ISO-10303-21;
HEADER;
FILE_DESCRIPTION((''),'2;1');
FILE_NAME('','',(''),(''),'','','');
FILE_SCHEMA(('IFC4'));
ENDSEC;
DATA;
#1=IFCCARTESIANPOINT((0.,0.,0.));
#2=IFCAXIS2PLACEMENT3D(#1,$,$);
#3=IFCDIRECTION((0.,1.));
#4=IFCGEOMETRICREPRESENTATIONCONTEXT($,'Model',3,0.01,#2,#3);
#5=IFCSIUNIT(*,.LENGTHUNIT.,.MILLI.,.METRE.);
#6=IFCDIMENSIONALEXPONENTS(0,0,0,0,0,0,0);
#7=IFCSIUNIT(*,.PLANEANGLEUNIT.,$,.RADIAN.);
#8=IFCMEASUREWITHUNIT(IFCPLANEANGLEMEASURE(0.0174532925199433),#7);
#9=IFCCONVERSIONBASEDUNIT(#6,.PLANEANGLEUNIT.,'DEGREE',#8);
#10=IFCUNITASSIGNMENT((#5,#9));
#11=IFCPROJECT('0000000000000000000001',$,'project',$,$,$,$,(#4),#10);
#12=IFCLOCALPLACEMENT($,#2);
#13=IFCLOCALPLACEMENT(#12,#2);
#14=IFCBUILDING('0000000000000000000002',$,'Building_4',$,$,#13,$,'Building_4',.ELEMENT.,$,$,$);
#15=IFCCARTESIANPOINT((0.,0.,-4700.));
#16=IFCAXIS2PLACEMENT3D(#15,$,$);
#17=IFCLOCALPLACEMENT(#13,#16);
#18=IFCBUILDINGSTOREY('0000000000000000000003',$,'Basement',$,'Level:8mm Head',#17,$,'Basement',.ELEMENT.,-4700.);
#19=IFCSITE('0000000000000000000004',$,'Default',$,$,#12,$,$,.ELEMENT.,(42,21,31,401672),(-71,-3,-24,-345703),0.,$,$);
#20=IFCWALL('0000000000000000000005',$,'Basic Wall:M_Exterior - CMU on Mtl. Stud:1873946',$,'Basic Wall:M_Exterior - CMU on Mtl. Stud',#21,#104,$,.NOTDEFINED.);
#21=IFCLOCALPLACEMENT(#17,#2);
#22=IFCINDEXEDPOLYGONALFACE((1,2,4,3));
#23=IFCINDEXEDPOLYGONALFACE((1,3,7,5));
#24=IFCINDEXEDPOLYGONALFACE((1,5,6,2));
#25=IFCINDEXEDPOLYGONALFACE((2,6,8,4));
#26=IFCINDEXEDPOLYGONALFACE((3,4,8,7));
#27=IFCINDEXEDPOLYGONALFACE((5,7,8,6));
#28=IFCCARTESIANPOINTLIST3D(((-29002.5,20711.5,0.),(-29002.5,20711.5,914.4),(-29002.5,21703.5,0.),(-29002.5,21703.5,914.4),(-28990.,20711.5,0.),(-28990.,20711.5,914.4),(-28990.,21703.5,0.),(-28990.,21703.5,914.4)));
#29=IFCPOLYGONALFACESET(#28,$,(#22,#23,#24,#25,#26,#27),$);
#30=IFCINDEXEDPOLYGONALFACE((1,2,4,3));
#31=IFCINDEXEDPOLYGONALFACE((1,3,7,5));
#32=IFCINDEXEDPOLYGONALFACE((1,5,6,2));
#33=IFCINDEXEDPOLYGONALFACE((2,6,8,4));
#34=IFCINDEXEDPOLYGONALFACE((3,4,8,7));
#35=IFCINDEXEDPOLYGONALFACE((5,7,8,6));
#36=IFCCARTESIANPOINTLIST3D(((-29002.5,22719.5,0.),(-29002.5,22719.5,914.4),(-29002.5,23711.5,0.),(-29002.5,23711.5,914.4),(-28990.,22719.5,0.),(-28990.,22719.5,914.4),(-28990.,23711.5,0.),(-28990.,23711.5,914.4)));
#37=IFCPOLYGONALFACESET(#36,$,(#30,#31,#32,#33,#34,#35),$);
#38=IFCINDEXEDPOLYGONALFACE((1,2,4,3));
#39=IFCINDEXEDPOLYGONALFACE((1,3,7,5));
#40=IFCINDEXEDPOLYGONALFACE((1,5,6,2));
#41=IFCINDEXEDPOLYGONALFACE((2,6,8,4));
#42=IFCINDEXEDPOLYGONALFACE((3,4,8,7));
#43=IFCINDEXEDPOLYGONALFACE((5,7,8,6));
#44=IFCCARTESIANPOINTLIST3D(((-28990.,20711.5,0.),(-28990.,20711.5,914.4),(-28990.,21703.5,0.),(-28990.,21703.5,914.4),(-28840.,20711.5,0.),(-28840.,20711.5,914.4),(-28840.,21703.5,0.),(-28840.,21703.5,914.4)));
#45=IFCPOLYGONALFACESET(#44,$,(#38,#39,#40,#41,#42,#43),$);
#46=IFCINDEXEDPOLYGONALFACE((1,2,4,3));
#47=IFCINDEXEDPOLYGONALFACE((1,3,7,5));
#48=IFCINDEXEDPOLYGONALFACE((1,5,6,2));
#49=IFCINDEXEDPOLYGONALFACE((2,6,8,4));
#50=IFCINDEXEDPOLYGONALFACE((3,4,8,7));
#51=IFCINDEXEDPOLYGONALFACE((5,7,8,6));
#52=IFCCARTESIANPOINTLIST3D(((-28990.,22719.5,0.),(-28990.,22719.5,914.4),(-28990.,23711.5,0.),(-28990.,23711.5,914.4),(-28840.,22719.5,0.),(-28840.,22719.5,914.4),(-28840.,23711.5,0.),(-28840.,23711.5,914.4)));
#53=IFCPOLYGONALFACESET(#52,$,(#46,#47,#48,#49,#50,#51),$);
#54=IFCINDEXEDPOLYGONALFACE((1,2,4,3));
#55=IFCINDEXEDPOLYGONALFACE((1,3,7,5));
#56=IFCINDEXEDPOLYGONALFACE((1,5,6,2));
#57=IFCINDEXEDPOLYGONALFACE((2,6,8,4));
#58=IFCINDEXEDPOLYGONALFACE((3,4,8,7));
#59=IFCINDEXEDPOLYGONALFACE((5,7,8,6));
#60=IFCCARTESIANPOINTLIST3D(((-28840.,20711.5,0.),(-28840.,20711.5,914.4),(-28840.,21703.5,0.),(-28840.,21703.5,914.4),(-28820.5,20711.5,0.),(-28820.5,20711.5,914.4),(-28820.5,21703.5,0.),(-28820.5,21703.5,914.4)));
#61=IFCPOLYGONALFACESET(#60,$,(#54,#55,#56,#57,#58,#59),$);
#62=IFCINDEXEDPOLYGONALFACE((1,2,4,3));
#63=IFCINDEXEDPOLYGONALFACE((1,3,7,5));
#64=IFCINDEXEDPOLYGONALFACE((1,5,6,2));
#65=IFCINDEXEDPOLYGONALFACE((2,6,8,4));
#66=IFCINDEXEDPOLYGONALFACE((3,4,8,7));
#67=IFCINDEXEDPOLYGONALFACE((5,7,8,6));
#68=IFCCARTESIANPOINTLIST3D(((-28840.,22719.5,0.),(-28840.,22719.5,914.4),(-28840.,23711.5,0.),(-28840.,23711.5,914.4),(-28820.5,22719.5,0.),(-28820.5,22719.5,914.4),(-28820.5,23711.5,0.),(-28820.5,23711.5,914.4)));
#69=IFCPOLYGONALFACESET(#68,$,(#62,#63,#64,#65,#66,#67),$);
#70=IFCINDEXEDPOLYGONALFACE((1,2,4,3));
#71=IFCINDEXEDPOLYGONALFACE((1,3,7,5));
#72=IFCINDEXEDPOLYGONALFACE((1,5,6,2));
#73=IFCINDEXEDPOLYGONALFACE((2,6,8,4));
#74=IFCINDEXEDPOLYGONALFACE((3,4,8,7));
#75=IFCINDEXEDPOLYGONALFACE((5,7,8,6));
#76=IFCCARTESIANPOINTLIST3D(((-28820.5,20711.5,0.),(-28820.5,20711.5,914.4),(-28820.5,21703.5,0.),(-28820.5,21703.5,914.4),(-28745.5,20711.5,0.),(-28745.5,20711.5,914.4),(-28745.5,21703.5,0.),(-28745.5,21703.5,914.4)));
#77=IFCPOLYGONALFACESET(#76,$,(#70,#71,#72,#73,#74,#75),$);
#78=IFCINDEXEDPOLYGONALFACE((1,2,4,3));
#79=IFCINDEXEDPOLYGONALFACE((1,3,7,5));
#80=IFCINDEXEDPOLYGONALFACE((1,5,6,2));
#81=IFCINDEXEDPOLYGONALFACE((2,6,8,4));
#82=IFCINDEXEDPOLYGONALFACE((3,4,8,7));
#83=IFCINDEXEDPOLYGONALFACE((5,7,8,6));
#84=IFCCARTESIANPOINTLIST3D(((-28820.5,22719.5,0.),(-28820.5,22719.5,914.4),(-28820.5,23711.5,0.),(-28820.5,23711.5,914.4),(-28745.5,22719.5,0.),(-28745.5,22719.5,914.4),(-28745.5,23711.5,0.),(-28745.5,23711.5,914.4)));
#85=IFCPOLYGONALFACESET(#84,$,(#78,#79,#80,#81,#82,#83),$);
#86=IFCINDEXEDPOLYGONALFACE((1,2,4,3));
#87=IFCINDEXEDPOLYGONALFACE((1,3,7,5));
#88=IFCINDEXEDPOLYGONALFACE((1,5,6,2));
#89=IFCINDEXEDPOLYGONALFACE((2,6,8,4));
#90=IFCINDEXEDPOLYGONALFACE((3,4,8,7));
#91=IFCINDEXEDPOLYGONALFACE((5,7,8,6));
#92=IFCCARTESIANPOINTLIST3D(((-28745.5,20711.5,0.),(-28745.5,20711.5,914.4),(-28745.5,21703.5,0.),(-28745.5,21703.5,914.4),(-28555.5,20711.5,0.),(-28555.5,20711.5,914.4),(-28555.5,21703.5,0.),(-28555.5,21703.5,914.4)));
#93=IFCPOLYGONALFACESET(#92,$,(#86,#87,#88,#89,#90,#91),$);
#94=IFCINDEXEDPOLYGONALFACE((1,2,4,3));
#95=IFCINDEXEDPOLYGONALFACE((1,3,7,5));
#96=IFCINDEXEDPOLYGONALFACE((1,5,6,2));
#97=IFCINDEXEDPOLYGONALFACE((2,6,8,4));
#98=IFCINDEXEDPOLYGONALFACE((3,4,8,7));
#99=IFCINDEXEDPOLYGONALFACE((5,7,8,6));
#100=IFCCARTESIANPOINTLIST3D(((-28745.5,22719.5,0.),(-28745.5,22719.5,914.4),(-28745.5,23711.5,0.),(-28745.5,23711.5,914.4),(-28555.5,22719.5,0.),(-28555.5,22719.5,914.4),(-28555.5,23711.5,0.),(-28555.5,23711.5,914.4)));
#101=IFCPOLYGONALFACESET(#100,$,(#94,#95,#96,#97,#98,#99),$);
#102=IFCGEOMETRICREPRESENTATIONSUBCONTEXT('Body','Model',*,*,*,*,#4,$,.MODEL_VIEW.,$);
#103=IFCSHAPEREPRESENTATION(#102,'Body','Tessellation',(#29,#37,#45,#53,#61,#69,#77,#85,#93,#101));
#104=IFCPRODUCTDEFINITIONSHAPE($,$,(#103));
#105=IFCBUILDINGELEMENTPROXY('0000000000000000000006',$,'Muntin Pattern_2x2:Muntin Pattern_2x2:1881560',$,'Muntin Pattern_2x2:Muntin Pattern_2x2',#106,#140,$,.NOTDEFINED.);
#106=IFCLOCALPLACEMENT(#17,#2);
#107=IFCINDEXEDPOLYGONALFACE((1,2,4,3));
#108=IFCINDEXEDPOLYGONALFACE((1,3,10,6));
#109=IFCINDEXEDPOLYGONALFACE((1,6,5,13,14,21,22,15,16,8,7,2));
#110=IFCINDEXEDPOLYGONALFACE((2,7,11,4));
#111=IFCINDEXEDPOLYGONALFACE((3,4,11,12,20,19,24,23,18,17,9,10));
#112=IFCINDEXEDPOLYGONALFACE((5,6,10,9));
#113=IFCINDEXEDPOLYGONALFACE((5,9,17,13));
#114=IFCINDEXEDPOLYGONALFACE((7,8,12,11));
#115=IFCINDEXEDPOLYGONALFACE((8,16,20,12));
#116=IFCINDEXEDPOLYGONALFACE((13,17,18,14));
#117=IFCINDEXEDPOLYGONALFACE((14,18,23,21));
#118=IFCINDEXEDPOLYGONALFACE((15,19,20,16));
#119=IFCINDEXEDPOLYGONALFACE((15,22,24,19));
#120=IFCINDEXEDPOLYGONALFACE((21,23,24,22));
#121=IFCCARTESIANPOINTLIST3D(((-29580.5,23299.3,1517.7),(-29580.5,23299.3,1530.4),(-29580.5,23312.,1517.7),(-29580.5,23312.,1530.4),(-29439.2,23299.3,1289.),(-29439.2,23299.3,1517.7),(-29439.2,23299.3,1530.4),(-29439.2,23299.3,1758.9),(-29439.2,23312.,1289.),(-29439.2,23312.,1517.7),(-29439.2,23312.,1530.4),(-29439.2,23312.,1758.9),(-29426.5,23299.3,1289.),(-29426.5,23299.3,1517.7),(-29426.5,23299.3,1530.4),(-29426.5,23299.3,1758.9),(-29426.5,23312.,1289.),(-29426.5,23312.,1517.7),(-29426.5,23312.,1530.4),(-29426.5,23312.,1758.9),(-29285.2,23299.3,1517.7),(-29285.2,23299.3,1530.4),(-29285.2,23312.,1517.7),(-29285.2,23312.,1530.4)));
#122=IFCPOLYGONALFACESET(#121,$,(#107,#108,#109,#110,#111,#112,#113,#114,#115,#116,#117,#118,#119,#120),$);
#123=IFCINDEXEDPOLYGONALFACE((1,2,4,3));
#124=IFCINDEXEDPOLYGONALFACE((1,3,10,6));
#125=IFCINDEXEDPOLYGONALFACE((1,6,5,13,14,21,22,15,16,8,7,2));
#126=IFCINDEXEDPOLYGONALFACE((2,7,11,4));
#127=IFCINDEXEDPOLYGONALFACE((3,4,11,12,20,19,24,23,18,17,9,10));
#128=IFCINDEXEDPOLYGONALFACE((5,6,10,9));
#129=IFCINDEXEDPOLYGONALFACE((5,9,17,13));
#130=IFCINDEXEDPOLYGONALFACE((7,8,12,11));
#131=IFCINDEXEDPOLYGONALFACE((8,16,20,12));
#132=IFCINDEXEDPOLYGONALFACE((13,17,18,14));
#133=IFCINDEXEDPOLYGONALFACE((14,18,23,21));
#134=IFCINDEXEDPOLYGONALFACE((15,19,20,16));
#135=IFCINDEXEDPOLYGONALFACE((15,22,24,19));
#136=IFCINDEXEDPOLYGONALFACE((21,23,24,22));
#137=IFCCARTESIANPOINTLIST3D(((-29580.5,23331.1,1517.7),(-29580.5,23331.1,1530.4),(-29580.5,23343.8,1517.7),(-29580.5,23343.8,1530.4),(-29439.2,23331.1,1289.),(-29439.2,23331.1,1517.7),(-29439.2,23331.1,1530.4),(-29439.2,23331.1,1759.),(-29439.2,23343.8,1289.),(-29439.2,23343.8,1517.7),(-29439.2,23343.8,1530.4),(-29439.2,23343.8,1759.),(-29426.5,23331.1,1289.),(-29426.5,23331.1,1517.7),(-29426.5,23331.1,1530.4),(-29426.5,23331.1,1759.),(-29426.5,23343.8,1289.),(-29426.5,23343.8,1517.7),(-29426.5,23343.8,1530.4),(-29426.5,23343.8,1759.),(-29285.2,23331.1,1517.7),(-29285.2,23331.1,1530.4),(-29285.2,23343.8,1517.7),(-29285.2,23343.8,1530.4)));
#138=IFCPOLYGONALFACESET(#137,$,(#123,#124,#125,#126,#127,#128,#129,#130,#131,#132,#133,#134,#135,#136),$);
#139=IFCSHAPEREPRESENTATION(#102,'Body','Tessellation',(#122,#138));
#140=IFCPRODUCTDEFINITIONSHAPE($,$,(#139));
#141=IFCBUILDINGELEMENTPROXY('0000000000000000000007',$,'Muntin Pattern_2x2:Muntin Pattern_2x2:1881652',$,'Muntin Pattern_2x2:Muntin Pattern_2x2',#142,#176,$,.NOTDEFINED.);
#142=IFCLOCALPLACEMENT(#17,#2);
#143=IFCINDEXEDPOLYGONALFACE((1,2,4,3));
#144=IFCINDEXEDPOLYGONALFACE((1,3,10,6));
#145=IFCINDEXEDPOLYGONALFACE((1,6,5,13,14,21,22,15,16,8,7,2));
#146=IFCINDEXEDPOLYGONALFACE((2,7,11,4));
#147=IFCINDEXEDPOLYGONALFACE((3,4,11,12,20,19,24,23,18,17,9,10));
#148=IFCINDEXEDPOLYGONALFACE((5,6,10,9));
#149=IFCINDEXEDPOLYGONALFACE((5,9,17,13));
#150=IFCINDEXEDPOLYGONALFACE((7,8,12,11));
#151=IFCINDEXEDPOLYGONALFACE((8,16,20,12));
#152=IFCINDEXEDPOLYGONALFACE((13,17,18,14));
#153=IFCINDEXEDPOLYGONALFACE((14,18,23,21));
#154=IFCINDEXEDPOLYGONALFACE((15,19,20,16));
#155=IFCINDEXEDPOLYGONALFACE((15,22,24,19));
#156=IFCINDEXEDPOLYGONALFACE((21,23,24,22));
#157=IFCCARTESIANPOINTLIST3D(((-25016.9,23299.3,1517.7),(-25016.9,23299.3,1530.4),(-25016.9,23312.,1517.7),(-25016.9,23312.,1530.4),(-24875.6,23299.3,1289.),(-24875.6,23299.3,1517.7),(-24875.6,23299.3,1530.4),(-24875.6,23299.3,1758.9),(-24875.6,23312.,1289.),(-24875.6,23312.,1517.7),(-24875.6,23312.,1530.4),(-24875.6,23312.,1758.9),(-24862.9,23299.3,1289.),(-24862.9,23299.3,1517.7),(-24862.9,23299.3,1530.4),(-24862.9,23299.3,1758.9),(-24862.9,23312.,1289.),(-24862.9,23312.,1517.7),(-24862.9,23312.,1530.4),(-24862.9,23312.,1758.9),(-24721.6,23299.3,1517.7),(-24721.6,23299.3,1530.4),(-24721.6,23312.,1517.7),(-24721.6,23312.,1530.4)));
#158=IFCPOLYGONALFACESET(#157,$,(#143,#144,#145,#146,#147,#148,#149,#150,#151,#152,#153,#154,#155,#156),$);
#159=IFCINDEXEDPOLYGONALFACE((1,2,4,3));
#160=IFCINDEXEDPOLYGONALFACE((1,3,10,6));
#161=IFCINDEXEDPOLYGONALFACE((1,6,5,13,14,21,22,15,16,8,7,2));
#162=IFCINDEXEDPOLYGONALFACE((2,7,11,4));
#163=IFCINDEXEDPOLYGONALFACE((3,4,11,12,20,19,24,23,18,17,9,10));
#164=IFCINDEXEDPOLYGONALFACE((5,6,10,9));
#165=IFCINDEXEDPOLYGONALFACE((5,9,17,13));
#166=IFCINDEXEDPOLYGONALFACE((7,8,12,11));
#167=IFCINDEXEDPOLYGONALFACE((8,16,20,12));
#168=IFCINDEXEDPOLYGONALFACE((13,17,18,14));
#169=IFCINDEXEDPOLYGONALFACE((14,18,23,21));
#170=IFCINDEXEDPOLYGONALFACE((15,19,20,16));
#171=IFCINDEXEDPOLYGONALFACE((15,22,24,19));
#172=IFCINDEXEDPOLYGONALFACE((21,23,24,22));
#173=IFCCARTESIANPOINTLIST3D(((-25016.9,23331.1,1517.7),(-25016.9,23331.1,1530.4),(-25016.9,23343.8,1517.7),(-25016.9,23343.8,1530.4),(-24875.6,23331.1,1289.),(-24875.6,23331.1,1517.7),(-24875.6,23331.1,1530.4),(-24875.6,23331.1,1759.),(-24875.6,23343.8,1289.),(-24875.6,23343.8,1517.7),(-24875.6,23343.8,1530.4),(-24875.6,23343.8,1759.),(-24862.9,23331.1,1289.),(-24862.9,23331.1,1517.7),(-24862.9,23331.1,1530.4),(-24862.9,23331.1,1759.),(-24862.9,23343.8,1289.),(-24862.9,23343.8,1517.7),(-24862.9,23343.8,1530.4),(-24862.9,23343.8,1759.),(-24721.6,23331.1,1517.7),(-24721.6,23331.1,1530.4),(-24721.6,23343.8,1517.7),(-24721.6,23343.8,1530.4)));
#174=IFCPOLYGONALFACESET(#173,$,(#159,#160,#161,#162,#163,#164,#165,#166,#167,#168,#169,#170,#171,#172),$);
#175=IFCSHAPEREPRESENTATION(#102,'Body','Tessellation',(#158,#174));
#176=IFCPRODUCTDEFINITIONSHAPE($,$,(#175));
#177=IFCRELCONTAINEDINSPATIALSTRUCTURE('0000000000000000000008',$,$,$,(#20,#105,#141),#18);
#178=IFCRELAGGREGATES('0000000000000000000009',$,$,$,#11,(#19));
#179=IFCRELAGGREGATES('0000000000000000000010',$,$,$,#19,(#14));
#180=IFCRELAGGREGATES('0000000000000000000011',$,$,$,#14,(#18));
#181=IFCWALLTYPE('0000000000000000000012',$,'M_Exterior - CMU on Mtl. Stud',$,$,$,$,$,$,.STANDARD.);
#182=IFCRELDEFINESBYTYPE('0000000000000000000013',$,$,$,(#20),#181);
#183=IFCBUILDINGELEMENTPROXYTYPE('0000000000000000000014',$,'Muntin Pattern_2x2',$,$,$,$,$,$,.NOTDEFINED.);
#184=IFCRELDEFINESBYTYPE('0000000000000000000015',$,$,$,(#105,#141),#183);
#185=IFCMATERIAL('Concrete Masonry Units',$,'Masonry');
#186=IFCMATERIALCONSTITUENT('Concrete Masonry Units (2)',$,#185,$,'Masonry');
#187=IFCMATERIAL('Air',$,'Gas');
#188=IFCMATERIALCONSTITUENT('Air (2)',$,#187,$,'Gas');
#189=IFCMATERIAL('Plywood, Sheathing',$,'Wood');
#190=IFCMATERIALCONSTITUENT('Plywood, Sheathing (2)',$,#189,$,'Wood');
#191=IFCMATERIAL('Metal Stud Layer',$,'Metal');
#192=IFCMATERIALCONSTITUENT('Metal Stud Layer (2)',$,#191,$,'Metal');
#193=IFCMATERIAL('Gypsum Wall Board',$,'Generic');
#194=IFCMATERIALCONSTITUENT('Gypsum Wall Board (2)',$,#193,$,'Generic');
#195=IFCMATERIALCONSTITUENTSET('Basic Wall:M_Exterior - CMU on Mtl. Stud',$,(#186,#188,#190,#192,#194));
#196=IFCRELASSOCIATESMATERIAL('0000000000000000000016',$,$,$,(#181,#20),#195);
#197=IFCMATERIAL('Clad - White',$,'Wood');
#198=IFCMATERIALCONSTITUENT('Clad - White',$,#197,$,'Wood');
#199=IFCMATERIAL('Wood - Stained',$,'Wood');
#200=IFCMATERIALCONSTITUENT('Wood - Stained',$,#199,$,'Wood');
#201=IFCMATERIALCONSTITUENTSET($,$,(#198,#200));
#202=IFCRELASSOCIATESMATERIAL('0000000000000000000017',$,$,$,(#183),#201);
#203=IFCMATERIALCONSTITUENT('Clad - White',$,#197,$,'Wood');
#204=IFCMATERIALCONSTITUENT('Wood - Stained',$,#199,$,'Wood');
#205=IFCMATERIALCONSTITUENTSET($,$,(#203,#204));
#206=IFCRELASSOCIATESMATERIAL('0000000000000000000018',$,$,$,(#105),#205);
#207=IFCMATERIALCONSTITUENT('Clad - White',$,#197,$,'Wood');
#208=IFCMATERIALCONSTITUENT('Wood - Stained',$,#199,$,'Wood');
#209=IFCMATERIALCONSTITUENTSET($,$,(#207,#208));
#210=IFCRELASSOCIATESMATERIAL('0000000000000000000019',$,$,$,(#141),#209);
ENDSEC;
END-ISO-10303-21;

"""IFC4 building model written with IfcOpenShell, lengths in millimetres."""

from ifc_helpers import new_model, entity, si_unit, converted_unit, direction, frame, origin, place, context, subcontext, project, spatial, indexed_curve, outline, extrude, source, transform, mapped, material, constituent, constituent_set, type_object, type_shapes, element, save


model = new_model("IFC4")

# Units and contexts
model_context = context("Model", 3, precision=0.01, world=origin(), true_north=direction((0.0, 1.0)))
body_context = subcontext(model_context, "Body", "Model", "MODEL_VIEW")
ifc_project = project(units=[si_unit("LENGTHUNIT", "METRE", prefix="MILLI"), converted_unit("PLANEANGLEUNIT", "DEGREE", entity("IfcPlaneAngleMeasure", 0.0174532925199433), si_unit("PLANEANGLEUNIT", "RADIAN"), dimensions=[0, 0, 0, 0, 0, 0, 0])], contexts=[model_context])

# Site, building, storey
site_placement = place(None, origin())
site = spatial("IfcSite", under=ifc_project, at=site_placement, Name="Default", CompositionType="ELEMENT", RefLatitude=(42, 21, 31, 401672), RefLongitude=(-71, -3, -24, -345703), RefElevation=0.0)
building_placement = place(site_placement, origin())
building = spatial("IfcBuilding", under=site, at=building_placement, Name="Building_4", LongName="Building_4", CompositionType="ELEMENT")
storey_placement = place(building_placement, frame((0.0, 0.0, -4700.0)))
storey = spatial("IfcBuildingStorey", under=building, at=storey_placement, Name="Basement", ObjectType="Level:8mm Head", LongName="Basement", CompositionType="ELEMENT", Elevation=-4700.0)

# Shared definitions
ifc_material_1 = material(Name="Air", Category="Gas")
ifc_material_2 = material(Name="Plywood, Sheathing", Category="Wood")
ifc_material_3 = material(Name="Metal Stud Layer", Category="Metal")
ifc_material_4 = material(Name="Gypsum Wall Board", Category="Generic")

# Wall, opening
ifc_material_5 = material(Name="Concrete Masonry Units", Category="Masonry")
ifc_constituent_1 = constituent(ifc_material_5, Name="Concrete Masonry Units (2)", Category="Masonry")
ifc_constituent_2 = constituent(ifc_material_1, Name="Air (2)", Category="Gas")
ifc_constituent_3 = constituent(ifc_material_2, Name="Plywood, Sheathing (2)", Category="Wood")
ifc_constituent_4 = constituent(ifc_material_3, Name="Metal Stud Layer (2)", Category="Metal")
ifc_constituent_5 = constituent(ifc_material_4, Name="Gypsum Wall Board (2)", Category="Generic")
ifc_constituent_set_1 = constituent_set(constituents=[ifc_constituent_1, ifc_constituent_2, ifc_constituent_3, ifc_constituent_4, ifc_constituent_5], Name="Basic Wall:M_Exterior - CMU on Mtl. Stud")
wall_type_1 = type_object("IfcWallType", Name="M_Exterior - CMU on Mtl. Stud", PredefinedType="STANDARD", material=ifc_constituent_set_1)
wall_1_placement = place(storey_placement, frame((-28779.0, 23711.5, 0.0), z_axis=(0.0, 0.0, 1.0), x_axis=(0.0, -1.0, 0.0)))
wall_1 = element("IfcWall", 1, at=wall_1_placement, inside=storey, type_object=wall_type_1, material=ifc_constituent_set_1, Name="Basic Wall:M_Exterior - CMU on Mtl. Stud:1873946", ObjectType="Basic Wall:M_Exterior - CMU on Mtl. Stud", PredefinedType="NOTDEFINED", context=body_context, shape_type="SweptSolid", body=[
    extrude(outline(indexed_curve([(-6.2, -496.0), (6.2, -496.0), (6.2, 496.0), (-6.2, 496.0), (-6.2, -496.0)], self_intersect=False)), frame((2504.0, -217.2, 0.0), z_axis=(0.0, 0.0, 1.0), x_axis=(0.0, 1.0, 0.0)), (0.0, 0.0, 1.0), 914.4),
    extrude(outline(indexed_curve([(-6.2, -496.0), (6.2, -496.0), (6.2, 496.0), (-6.2, 496.0), (-6.2, -496.0)], self_intersect=False)), frame((496.0, -217.2, 0.0), z_axis=(0.0, 0.0, 1.0), x_axis=(0.0, 1.0, 0.0)), (0.0, 0.0, 1.0), 914.4),
    extrude(outline(indexed_curve([(-496.0, -75.0), (496.0, -75.0), (496.0, 75.0), (-496.0, 75.0), (-496.0, -75.0)], self_intersect=False)), frame((2504.0, -136.0, 0.0)), (0.0, 0.0, 1.0), 914.4),
    extrude(outline(indexed_curve([(-496.0, -75.0), (496.0, -75.0), (496.0, 75.0), (-496.0, 75.0), (-496.0, -75.0)], self_intersect=False)), frame((496.0, -136.0, 0.0)), (0.0, 0.0, 1.0), 914.4),
    extrude(outline(indexed_curve([(-496.0, -9.7), (496.0, -9.7), (496.0, 9.8), (-496.0, 9.8), (-496.0, -9.7)], self_intersect=False)), frame((2504.0, -51.3, 0.0)), (0.0, 0.0, 1.0), 914.4),
    extrude(outline(indexed_curve([(-496.0, -9.7), (496.0, -9.7), (496.0, 9.8), (-496.0, 9.8), (-496.0, -9.7)], self_intersect=False)), frame((496.0, -51.3, 0.0)), (0.0, 0.0, 1.0), 914.4),
    extrude(outline(indexed_curve([(-496.0, -37.5), (496.0, -37.5), (496.0, 37.5), (-496.0, 37.5), (-496.0, -37.5)], self_intersect=False)), frame((2504.0, -4.0, 0.0)), (0.0, 0.0, 1.0), 914.4),
    extrude(outline(indexed_curve([(-496.0, -37.5), (496.0, -37.5), (496.0, 37.5), (-496.0, 37.5), (-496.0, -37.5)], self_intersect=False)), frame((496.0, -4.0, 0.0)), (0.0, 0.0, 1.0), 914.4),
    extrude(outline(indexed_curve([(-95.0, -496.0), (95.0, -496.0), (95.0, 496.0), (-95.0, 496.0), (-95.0, -496.0)], self_intersect=False)), frame((2504.0, 128.5, 0.0), z_axis=(0.0, 0.0, 1.0), x_axis=(0.0, -1.0, 0.0)), (0.0, 0.0, 1.0), 914.4),
    extrude(outline(indexed_curve([(-95.0, -496.0), (95.0, -496.0), (95.0, 496.0), (-95.0, 496.0), (-95.0, -496.0)], self_intersect=False)), frame((496.0, 128.5, 0.0), z_axis=(0.0, 0.0, 1.0), x_axis=(0.0, -1.0, 0.0)), (0.0, 0.0, 1.0), 914.4),
])
opening_1_placement = place(wall_1_placement, origin())
element("IfcOpeningElement", 2, at=opening_1_placement, cuts=wall_1, PredefinedType="OPENING", context=body_context, shape_type="SweptSolid", body=[
    extrude(outline(indexed_curve([(-508.0, -1117.6), (508.0, -1117.6), (508.0, 1117.6), (-508.0, 1117.6), (-508.0, -1117.6)], self_intersect=False)), frame((1500.0, -1747.5, 1117.6), z_axis=(0.0, 1.0, 0.0), x_axis=(-1.0, 0.0, 0.0)), (0.0, 0.0, 1.0), 3048.0),
])

# Building element proxies
ifc_material_6 = material(Name="Clad - White", Category="Wood")
ifc_constituent_6 = constituent(ifc_material_6, Name="Clad - White", Category="Wood")
ifc_material_7 = material(Name="Wood - Stained", Category="Wood")
ifc_constituent_7 = constituent(ifc_material_7, Name="Wood - Stained", Category="Wood")
ifc_constituent_set_2 = constituent_set(constituents=[ifc_constituent_6, ifc_constituent_7])
ifc_constituent_8 = constituent(ifc_material_6, Name="Clad - White", Category="Wood")
ifc_constituent_9 = constituent(ifc_material_7, Name="Wood - Stained", Category="Wood")
ifc_constituent_set_3 = constituent_set(constituents=[ifc_constituent_8, ifc_constituent_9])
building_element_proxy_type_1 = type_object("IfcBuildingElementProxyType", Name="Muntin Pattern_2x2", PredefinedType="NOTDEFINED", material=ifc_constituent_set_3)
shared_shape_1 = source(origin(), body_context, "Body", "SweptSolid", [
    extrude(outline(indexed_curve([(6.4, -6.4), (234.9, -6.4), (234.9, 6.3), (6.4, 6.3), (6.4, 147.6), (-6.3, 147.6), (-6.3, 6.3), (-235.0, 6.3), (-235.0, -6.4), (-6.3, -6.4), (-6.3, -147.6), (6.4, -147.6), (6.4, -6.4)], self_intersect=False)), frame((0.0, 9.5, 235.0), z_axis=(0.0, 1.0, 0.0), x_axis=(0.0, 0.0, 1.0)), (0.0, 0.0, 1.0), 12.7),
    extrude(outline(indexed_curve([(6.4, -6.4), (235.0, -6.4), (235.0, 6.3), (6.4, 6.3), (6.4, 147.6), (-6.3, 147.6), (-6.3, 6.3), (-235.0, 6.3), (-235.0, -6.4), (-6.3, -6.4), (-6.3, -147.6), (6.4, -147.6), (6.4, -6.4)], self_intersect=False)), frame((0.0, -22.2, 235.0), z_axis=(0.0, 1.0, 0.0), x_axis=(0.0, 0.0, 1.0)), (0.0, 0.0, 1.0), 12.7),
])
type_shapes(building_element_proxy_type_1, [shared_shape_1])
proxy_1_placement = place(storey_placement, frame((-29432.9, 23321.5, 1289.0), z_axis=(0.0, 0.0, 1.0), x_axis=(-1.0, 0.0, 0.0)))
element("IfcBuildingElementProxy", 3, at=proxy_1_placement, inside=storey, type_object=building_element_proxy_type_1, material=ifc_constituent_set_2, Name="Muntin Pattern_2x2:Muntin Pattern_2x2:1881560", ObjectType="Muntin Pattern_2x2:Muntin Pattern_2x2", PredefinedType="NOTDEFINED", context=body_context, shape_type="MappedRepresentation", body=[
    mapped(shared_shape_1, transform((0.0, 0.0, 0.0), scale=1.0)),
])
ifc_constituent_10 = constituent(ifc_material_6, Name="Clad - White", Category="Wood")
ifc_constituent_11 = constituent(ifc_material_7, Name="Wood - Stained", Category="Wood")
ifc_constituent_set_4 = constituent_set(constituents=[ifc_constituent_10, ifc_constituent_11])
proxy_2_placement = place(storey_placement, frame((-24869.3, 23321.5, 1289.0), z_axis=(0.0, 0.0, 1.0), x_axis=(-1.0, 0.0, 0.0)))
element("IfcBuildingElementProxy", 4, at=proxy_2_placement, inside=storey, type_object=building_element_proxy_type_1, material=ifc_constituent_set_4, Name="Muntin Pattern_2x2:Muntin Pattern_2x2:1881652", ObjectType="Muntin Pattern_2x2:Muntin Pattern_2x2", PredefinedType="NOTDEFINED", context=body_context, shape_type="MappedRepresentation", body=[
    mapped(shared_shape_1, transform((0.0, 0.0, 0.0), scale=1.0)),
])

save(model, "model.ifc")
